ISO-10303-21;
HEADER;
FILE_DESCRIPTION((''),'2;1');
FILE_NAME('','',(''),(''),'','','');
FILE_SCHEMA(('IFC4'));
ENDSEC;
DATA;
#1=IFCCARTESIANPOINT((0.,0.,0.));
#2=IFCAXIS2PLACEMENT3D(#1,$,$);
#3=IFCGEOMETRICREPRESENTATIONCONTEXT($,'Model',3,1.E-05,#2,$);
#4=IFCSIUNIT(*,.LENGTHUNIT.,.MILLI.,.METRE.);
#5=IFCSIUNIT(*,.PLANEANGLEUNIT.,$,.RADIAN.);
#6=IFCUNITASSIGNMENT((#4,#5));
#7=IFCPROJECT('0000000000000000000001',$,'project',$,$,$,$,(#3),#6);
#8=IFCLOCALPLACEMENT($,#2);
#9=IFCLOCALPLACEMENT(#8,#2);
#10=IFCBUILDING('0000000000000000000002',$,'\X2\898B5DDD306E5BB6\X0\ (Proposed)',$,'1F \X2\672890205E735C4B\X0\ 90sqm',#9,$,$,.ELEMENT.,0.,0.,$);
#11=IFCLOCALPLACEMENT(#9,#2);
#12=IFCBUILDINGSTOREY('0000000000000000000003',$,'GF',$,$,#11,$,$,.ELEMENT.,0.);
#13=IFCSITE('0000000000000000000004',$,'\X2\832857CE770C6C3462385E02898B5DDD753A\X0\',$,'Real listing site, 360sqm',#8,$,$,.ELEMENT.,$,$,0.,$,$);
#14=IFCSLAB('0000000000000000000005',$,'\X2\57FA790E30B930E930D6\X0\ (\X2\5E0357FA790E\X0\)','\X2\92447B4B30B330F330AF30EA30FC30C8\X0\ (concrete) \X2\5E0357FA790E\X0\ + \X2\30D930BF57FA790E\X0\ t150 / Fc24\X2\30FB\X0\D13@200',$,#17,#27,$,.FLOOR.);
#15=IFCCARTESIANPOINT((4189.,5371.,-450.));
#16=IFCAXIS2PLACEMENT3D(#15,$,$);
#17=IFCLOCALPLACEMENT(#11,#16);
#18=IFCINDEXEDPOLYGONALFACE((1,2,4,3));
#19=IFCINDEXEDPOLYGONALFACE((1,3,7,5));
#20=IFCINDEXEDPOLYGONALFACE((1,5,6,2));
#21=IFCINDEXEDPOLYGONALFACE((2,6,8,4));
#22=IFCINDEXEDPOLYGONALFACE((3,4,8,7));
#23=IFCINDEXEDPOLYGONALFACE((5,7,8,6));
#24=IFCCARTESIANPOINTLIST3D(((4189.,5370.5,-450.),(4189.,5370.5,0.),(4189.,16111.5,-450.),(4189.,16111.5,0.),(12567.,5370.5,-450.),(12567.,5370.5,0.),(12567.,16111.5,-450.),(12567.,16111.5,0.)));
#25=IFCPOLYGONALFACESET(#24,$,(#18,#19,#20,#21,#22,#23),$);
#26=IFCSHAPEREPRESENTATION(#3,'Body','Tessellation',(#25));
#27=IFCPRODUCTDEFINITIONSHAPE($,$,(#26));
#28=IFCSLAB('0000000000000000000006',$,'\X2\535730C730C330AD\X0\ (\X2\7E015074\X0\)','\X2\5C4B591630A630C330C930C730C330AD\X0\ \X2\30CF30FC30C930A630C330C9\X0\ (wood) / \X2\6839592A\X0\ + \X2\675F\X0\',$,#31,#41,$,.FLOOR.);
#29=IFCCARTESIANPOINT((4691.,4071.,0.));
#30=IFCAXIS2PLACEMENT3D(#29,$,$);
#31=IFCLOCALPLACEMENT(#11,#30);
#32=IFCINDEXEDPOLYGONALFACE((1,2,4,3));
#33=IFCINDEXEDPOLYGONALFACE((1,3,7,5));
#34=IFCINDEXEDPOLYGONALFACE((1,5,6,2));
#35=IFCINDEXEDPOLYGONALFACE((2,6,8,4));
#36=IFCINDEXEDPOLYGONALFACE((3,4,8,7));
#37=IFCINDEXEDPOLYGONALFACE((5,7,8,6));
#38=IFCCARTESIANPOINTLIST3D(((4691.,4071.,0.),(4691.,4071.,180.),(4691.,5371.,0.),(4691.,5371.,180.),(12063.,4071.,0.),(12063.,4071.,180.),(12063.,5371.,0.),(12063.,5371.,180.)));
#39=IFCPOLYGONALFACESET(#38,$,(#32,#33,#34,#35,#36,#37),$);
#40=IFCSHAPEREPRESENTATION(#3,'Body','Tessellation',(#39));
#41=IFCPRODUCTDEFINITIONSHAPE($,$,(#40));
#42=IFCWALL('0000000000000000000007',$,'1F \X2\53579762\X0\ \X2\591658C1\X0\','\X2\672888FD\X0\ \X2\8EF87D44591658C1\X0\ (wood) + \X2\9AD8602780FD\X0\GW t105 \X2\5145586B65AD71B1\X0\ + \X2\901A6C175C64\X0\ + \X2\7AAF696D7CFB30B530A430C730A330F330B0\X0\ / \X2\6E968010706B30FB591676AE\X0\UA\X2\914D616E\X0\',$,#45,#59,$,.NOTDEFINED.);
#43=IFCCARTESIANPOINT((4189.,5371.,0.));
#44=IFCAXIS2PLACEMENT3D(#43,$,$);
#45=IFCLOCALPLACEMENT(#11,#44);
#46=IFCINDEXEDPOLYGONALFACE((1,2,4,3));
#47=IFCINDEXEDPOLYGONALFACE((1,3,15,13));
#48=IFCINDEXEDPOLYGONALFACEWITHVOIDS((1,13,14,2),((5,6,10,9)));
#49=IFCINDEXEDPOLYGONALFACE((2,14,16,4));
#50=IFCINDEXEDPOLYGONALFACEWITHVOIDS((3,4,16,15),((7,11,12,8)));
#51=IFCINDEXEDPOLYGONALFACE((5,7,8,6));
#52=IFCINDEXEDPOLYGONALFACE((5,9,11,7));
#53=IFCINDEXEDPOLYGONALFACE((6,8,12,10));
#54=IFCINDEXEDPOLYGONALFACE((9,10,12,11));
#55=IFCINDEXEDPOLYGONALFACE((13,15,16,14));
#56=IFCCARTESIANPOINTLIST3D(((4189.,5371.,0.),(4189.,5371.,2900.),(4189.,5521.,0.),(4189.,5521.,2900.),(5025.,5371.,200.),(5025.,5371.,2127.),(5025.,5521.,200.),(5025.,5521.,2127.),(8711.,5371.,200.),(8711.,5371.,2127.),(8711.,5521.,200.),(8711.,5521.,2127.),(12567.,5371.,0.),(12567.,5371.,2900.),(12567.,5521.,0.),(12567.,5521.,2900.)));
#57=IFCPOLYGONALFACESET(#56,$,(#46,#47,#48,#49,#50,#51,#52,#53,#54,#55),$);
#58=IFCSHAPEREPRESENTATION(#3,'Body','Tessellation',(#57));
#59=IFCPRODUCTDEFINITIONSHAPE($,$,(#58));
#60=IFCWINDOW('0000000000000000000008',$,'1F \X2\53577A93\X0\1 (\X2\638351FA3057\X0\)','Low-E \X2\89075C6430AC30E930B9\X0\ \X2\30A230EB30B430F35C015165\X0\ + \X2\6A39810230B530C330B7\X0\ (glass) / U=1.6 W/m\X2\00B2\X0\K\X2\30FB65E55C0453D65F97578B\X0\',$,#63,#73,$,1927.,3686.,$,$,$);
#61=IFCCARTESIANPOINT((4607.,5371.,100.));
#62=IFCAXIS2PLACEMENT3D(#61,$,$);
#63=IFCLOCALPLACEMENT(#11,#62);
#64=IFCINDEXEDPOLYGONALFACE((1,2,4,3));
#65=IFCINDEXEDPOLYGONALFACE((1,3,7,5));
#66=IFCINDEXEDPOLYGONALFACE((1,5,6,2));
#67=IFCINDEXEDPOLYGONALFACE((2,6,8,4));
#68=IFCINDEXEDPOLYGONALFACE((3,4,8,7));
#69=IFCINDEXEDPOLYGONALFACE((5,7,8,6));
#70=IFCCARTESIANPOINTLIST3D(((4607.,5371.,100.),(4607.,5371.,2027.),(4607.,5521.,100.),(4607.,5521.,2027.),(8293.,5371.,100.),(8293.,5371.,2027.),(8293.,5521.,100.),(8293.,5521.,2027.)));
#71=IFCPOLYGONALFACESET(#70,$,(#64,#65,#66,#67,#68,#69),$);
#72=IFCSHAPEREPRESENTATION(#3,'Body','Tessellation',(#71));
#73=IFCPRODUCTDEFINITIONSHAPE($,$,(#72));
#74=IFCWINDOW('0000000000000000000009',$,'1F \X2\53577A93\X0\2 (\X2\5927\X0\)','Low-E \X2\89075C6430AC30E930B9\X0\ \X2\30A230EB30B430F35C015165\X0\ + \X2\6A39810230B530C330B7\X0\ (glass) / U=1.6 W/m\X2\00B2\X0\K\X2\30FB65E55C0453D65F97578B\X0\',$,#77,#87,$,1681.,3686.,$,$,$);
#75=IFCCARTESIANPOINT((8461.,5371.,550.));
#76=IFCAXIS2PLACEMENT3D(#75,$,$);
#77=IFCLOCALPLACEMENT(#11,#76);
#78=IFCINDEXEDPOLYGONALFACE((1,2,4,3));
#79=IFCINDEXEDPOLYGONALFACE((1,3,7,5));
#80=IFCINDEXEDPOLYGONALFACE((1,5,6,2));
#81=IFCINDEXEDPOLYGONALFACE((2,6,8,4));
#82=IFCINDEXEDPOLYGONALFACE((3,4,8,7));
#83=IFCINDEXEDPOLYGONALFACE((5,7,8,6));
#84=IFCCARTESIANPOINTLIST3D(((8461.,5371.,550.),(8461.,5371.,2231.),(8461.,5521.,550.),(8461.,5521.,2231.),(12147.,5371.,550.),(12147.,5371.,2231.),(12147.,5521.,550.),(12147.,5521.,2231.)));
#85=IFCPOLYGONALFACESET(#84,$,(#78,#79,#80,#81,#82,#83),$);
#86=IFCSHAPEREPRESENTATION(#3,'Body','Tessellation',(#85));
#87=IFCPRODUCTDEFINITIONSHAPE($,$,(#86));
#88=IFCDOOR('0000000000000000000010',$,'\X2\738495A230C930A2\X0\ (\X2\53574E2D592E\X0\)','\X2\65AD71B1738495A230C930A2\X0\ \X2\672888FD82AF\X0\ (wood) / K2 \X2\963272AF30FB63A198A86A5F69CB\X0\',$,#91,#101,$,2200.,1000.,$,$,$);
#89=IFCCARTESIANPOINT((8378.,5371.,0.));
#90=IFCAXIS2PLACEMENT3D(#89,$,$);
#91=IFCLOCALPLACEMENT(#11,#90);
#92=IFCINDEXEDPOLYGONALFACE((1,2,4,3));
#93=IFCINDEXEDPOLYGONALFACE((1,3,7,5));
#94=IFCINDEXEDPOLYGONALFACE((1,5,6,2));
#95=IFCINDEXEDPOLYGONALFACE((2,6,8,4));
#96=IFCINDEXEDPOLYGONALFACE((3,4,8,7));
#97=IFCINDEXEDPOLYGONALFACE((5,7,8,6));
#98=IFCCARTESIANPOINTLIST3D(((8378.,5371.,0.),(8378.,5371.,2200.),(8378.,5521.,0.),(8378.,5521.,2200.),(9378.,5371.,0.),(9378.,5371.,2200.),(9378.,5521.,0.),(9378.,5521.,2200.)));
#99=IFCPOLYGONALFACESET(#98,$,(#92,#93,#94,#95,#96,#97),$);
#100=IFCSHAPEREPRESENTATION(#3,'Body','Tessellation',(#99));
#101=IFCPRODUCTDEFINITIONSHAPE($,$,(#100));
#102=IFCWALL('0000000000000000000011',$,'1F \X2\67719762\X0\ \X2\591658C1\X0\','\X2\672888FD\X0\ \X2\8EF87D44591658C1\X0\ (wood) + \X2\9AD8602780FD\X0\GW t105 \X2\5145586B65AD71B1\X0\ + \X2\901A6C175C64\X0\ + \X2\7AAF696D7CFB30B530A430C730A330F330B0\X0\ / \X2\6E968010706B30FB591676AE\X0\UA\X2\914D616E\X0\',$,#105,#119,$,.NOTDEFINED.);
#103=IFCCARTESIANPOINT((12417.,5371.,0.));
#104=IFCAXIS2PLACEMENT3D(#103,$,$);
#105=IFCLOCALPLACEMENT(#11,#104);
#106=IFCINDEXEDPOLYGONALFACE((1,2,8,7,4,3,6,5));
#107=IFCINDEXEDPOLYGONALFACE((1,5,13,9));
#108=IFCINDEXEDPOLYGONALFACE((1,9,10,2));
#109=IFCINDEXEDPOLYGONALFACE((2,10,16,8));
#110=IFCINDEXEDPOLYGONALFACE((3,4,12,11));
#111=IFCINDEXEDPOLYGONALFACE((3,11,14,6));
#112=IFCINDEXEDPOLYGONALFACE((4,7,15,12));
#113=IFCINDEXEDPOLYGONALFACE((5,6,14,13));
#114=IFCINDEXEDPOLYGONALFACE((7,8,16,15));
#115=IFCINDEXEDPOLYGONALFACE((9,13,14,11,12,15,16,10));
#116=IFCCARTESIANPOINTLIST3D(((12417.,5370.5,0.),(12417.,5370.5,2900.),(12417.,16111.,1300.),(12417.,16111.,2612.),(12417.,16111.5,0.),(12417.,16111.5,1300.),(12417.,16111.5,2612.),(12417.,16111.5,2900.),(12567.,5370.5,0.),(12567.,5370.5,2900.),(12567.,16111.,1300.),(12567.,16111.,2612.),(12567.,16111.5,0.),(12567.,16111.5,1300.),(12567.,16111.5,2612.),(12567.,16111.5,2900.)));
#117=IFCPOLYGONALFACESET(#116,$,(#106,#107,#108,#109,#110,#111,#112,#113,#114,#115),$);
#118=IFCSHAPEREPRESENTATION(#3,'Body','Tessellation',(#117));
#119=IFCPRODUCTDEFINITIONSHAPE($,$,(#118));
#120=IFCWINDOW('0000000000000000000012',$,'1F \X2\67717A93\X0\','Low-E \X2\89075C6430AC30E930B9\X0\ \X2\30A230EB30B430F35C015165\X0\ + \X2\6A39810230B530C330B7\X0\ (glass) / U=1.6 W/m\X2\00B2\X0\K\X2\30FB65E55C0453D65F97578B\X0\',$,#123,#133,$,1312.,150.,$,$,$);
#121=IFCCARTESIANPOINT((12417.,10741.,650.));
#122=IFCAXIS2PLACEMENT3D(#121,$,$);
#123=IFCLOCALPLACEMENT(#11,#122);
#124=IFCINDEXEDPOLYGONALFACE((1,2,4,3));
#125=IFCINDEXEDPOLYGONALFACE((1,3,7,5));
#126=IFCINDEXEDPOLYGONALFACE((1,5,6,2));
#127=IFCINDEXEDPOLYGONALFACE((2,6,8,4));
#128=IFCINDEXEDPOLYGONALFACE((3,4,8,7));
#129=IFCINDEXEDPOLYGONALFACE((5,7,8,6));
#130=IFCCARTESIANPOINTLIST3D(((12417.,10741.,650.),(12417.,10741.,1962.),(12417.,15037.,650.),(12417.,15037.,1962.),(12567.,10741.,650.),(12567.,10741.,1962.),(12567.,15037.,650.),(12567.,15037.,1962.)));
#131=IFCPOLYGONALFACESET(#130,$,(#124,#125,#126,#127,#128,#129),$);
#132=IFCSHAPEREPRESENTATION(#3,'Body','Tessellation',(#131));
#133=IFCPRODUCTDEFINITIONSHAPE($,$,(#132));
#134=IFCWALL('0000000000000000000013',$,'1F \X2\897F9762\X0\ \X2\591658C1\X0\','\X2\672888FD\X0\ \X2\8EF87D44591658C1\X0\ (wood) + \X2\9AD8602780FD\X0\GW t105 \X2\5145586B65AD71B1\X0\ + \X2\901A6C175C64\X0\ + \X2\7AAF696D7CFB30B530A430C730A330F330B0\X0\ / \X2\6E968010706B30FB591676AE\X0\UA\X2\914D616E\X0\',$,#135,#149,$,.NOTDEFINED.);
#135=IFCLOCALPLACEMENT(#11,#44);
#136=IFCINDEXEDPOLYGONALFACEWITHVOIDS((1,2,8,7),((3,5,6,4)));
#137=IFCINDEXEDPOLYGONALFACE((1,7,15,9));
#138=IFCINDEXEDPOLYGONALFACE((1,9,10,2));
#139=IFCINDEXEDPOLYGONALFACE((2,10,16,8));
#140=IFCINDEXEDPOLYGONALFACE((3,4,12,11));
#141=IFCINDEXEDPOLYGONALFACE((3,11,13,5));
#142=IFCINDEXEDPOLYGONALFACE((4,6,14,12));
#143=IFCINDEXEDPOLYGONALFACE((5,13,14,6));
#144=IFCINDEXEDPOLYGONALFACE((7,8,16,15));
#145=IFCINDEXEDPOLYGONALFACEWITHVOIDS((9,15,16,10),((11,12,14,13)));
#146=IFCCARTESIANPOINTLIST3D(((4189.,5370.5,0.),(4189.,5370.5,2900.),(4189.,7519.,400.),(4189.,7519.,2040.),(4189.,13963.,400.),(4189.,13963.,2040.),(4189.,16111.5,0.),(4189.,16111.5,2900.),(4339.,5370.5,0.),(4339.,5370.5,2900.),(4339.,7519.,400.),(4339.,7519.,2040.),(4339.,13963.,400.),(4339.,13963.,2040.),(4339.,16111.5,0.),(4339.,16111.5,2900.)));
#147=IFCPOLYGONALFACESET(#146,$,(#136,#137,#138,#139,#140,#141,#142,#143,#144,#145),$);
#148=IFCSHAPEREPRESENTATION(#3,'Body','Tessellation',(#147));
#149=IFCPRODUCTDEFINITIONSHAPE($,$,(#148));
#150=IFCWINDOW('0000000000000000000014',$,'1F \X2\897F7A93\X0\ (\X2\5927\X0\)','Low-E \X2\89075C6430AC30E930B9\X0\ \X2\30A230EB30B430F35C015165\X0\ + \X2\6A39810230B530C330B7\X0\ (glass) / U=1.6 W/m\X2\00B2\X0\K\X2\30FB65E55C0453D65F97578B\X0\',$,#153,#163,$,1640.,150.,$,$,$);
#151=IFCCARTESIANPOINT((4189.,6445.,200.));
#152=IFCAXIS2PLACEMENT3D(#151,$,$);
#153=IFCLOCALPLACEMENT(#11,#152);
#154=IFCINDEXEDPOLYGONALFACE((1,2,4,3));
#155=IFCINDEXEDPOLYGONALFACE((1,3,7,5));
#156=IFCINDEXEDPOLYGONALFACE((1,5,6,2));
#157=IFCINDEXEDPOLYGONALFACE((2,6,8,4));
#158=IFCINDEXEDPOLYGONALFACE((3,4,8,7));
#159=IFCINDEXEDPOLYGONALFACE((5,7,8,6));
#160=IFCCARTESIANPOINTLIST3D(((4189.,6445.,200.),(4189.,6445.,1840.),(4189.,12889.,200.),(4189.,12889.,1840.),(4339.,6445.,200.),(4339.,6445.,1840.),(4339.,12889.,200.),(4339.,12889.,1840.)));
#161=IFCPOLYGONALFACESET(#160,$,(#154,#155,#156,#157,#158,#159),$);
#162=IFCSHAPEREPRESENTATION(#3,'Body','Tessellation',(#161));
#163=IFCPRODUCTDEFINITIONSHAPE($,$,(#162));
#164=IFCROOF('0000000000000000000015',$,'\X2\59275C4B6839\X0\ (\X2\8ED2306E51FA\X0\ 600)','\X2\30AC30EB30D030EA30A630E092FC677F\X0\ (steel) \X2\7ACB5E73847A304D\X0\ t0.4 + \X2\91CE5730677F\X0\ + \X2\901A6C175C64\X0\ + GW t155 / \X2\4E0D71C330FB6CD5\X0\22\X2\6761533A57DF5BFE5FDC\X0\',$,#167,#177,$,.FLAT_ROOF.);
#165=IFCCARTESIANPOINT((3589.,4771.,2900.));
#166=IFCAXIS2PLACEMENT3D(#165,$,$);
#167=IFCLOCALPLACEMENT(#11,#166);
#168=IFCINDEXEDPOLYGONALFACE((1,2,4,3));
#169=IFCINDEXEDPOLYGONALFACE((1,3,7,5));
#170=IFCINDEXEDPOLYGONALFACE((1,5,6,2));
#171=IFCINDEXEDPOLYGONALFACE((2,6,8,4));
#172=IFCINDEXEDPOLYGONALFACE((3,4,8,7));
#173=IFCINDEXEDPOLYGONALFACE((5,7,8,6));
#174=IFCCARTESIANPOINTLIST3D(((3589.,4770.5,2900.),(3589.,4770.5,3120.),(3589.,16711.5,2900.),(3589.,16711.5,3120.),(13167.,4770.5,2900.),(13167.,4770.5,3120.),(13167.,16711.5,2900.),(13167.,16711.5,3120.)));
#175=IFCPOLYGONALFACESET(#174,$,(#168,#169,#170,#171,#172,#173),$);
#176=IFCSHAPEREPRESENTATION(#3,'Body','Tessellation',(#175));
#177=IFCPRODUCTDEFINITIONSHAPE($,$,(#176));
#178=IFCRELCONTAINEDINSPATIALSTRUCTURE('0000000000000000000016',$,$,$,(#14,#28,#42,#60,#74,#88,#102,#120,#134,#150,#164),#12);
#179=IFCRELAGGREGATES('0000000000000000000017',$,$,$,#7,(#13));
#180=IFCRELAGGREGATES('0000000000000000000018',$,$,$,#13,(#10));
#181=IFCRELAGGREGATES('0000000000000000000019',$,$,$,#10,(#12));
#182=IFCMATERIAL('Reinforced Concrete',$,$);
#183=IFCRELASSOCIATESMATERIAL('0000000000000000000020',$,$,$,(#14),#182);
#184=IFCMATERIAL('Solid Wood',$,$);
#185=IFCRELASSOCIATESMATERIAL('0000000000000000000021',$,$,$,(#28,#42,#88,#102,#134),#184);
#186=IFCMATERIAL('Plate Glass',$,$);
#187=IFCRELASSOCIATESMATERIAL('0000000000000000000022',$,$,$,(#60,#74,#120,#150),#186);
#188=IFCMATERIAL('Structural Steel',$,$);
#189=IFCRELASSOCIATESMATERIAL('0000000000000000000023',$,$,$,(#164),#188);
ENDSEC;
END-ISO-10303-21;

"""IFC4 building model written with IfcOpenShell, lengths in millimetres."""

from ifc_helpers import new_model, si_unit, frame, frame_2d, origin, place, context, project, spatial, rectangle, extrude, material, element, fill, save


model = new_model("IFC4")

# Units and contexts
model_context = context("Model", 3, precision=1e-05, world=origin())
ifc_project = project(units=[si_unit("LENGTHUNIT", "METRE", prefix="MILLI"), si_unit("PLANEANGLEUNIT", "RADIAN")], contexts=[model_context])

# Site, building, storey
site_placement = place(None, origin())
site = spatial("IfcSite", under=ifc_project, at=site_placement, Name="茨城県水戸市見川町", ObjectType="Real listing site, 360sqm", CompositionType="ELEMENT", RefElevation=0.0)
building_placement = place(site_placement, origin())
building = spatial("IfcBuilding", under=site, at=building_placement, Name="見川の家 (Proposed)", ObjectType="1F 木造平屋 90sqm", CompositionType="ELEMENT", ElevationOfRefHeight=0.0, ElevationOfTerrain=0.0)
storey_placement = place(building_placement, origin())
storey = spatial("IfcBuildingStorey", under=building, at=storey_placement, Name="GF", CompositionType="ELEMENT", Elevation=0.0)

# Slabs
ifc_material_1 = material(Name="Reinforced Concrete")
slab_1_placement = place(storey_placement, frame((4189.0, 5371.0, -450.0)))
element("IfcSlab", 1, at=slab_1_placement, inside=storey, material=ifc_material_1, Name="基礎スラブ (布基礎)", Description="鉄筋コンクリート (concrete) 布基礎 + ベタ基礎 t150 / Fc24・D13@200", PredefinedType="FLOOR", context=model_context, shape_type="SweptSolid", body=[
    extrude(rectangle(XDim=8378.0, YDim=10741.0, at=frame_2d((4189.0, 5370.0))), frame((4189.0, 5371.0, -450.0)), (0.0, 0.0, 1.0), 450.0),
])
ifc_material_2 = material(Name="Solid Wood")
slab_2_placement = place(storey_placement, frame((4691.0, 4071.0, 0.0)))
element("IfcSlab", 2, at=slab_2_placement, inside=storey, material=ifc_material_2, Name="南デッキ (縁側)", Description="屋外ウッドデッキ ハードウッド (wood) / 根太 + 束", PredefinedType="FLOOR", context=model_context, shape_type="SweptSolid", body=[
    extrude(rectangle(XDim=7372.0, YDim=1300.0, at=frame_2d((3686.0, 650.0))), frame((4691.0, 4071.0, 0.0)), (0.0, 0.0, 1.0), 180.0),
])

# Wall, openings, windows, door
wall_1_placement = place(storey_placement, frame((4189.0, 5371.0, 0.0)))
wall_1 = element("IfcWall", 3, at=wall_1_placement, inside=storey, material=ifc_material_2, Name="1F 南面 外壁", Description="木製 軸組外壁 (wood) + 高性能GW t105 充填断熱 + 通気層 + 窯業系サイディング / 準耐火・外皮UA配慮", PredefinedType="NOTDEFINED", context=model_context, shape_type="SweptSolid", body=[
    extrude(rectangle(XDim=8378.0, YDim=150.0, at=frame_2d((4189.0, 75.0))), frame((4189.0, 5371.0, 0.0)), (0.0, 0.0, 1.0), 2900.0),
])
opening_1_placement = place(storey_placement, frame((4607.0, 5371.0, 100.0)))
opening_1 = element("IfcOpeningElement", 4, at=opening_1_placement, cuts=wall_1, PredefinedType="NOTDEFINED", context=model_context, shape_type="SweptSolid", body=[
    extrude(rectangle(XDim=3686.0, YDim=150.0, at=frame_2d((1843.0, 75.0))), frame((4607.0, 5371.0, 100.0)), (0.0, 0.0, 1.0), 1927.0),
])
opening_2_placement = place(storey_placement, frame((8461.0, 5371.0, 550.0)))
opening_2 = element("IfcOpeningElement", 5, at=opening_2_placement, cuts=wall_1, PredefinedType="NOTDEFINED", context=model_context, shape_type="SweptSolid", body=[
    extrude(rectangle(XDim=3686.0, YDim=150.0, at=frame_2d((1843.0, 75.0))), frame((8461.0, 5371.0, 550.0)), (0.0, 0.0, 1.0), 1681.0),
])
opening_3_placement = place(storey_placement, frame((8378.0, 5371.0, 0.0)))
opening_3 = element("IfcOpeningElement", 6, at=opening_3_placement, cuts=wall_1, PredefinedType="NOTDEFINED", context=model_context, shape_type="SweptSolid", body=[
    extrude(rectangle(XDim=1000.0, YDim=150.0, at=frame_2d((500.0, 75.0))), frame((8378.0, 5371.0, 0.0)), (0.0, 0.0, 1.0), 2200.0),
])
ifc_material_3 = material(Name="Plate Glass")
window_1_placement = place(storey_placement, frame((4607.0, 5371.0, 100.0)))
window_1 = element("IfcWindow", 7, at=window_1_placement, inside=storey, material=ifc_material_3, Name="1F 南窓1 (掃出し)", Description="Low-E 複層ガラス アルゴン封入 + 樹脂サッシ (glass) / U=1.6 W/m²K・日射取得型", OverallHeight=1927.0, OverallWidth=3686.0, context=model_context, shape_type="SweptSolid", body=[
    extrude(rectangle(XDim=3686.0, YDim=150.0, at=frame_2d((1843.0, 75.0))), frame((4607.0, 5371.0, 100.0)), (0.0, 0.0, 1.0), 1927.0),
])
fill(opening_1, window_1)
window_2_placement = place(storey_placement, frame((8461.0, 5371.0, 550.0)))
window_2 = element("IfcWindow", 8, at=window_2_placement, inside=storey, material=ifc_material_3, Name="1F 南窓2 (大)", Description="Low-E 複層ガラス アルゴン封入 + 樹脂サッシ (glass) / U=1.6 W/m²K・日射取得型", OverallHeight=1681.0, OverallWidth=3686.0, context=model_context, shape_type="SweptSolid", body=[
    extrude(rectangle(XDim=3686.0, YDim=150.0, at=frame_2d((1843.0, 75.0))), frame((8461.0, 5371.0, 550.0)), (0.0, 0.0, 1.0), 1681.0),
])
fill(opening_2, window_2)
door_placement = place(storey_placement, frame((8378.0, 5371.0, 0.0)))
door = element("IfcDoor", 9, at=door_placement, inside=storey, material=ifc_material_2, Name="玄関ドア (南中央)", Description="断熱玄関ドア 木製芯 (wood) / K2 防犯・採風機構", OverallHeight=2200.0, OverallWidth=1000.0, context=model_context, shape_type="SweptSolid", body=[
    extrude(rectangle(XDim=1000.0, YDim=150.0, at=frame_2d((500.0, 75.0))), frame((8378.0, 5371.0, 0.0)), (0.0, 0.0, 1.0), 2200.0),
])
fill(opening_3, door)

# Walls, openings, windows
wall_2_placement = place(storey_placement, frame((12417.0, 5371.0, 0.0)))
wall_2 = element("IfcWall", 10, at=wall_2_placement, inside=storey, material=ifc_material_2, Name="1F 東面 外壁", Description="木製 軸組外壁 (wood) + 高性能GW t105 充填断熱 + 通気層 + 窯業系サイディング / 準耐火・外皮UA配慮", PredefinedType="NOTDEFINED", context=model_context, shape_type="SweptSolid", body=[
    extrude(rectangle(XDim=150.0, YDim=10741.0, at=frame_2d((75.0, 5370.0))), frame((12417.0, 5371.0, 0.0)), (0.0, 0.0, 1.0), 2900.0),
])
opening_4_placement = place(storey_placement, frame((12417.0, 10741.0, 650.0)))
opening_4 = element("IfcOpeningElement", 11, at=opening_4_placement, cuts=wall_2, PredefinedType="NOTDEFINED", context=model_context, shape_type="SweptSolid", body=[
    extrude(rectangle(XDim=150.0, YDim=4296.0, at=frame_2d((75.0, 2148.0))), frame((12417.0, 10741.0, 650.0)), (0.0, 0.0, 1.0), 1312.0),
])
window_3_placement = place(storey_placement, frame((12417.0, 10741.0, 650.0)))
window_3 = element("IfcWindow", 12, at=window_3_placement, inside=storey, material=ifc_material_3, Name="1F 東窓", Description="Low-E 複層ガラス アルゴン封入 + 樹脂サッシ (glass) / U=1.6 W/m²K・日射取得型", OverallHeight=1312.0, OverallWidth=150.0, context=model_context, shape_type="SweptSolid", body=[
    extrude(rectangle(XDim=150.0, YDim=4296.0, at=frame_2d((75.0, 2148.0))), frame((12417.0, 10741.0, 650.0)), (0.0, 0.0, 1.0), 1312.0),
])
fill(opening_4, window_3)
wall_3_placement = place(storey_placement, frame((4189.0, 5371.0, 0.0)))
wall_3 = element("IfcWall", 13, at=wall_3_placement, inside=storey, material=ifc_material_2, Name="1F 西面 外壁", Description="木製 軸組外壁 (wood) + 高性能GW t105 充填断熱 + 通気層 + 窯業系サイディング / 準耐火・外皮UA配慮", PredefinedType="NOTDEFINED", context=model_context, shape_type="SweptSolid", body=[
    extrude(rectangle(XDim=150.0, YDim=10741.0, at=frame_2d((75.0, 5370.0))), frame((4189.0, 5371.0, 0.0)), (0.0, 0.0, 1.0), 2900.0),
])
opening_5_placement = place(storey_placement, frame((4189.0, 6445.0, 200.0)))
opening_5 = element("IfcOpeningElement", 14, at=opening_5_placement, cuts=wall_3, PredefinedType="NOTDEFINED", context=model_context, shape_type="SweptSolid", body=[
    extrude(rectangle(XDim=150.0, YDim=6444.0, at=frame_2d((75.0, 3222.0))), frame((4189.0, 6445.0, 200.0)), (0.0, 0.0, 1.0), 1640.0),
])
window_4_placement = place(storey_placement, frame((4189.0, 6445.0, 200.0)))
window_4 = element("IfcWindow", 15, at=window_4_placement, inside=storey, material=ifc_material_3, Name="1F 西窓 (大)", Description="Low-E 複層ガラス アルゴン封入 + 樹脂サッシ (glass) / U=1.6 W/m²K・日射取得型", OverallHeight=1640.0, OverallWidth=150.0, context=model_context, shape_type="SweptSolid", body=[
    extrude(rectangle(XDim=150.0, YDim=6444.0, at=frame_2d((75.0, 3222.0))), frame((4189.0, 6445.0, 200.0)), (0.0, 0.0, 1.0), 1640.0),
])
fill(opening_5, window_4)

# Roof
ifc_material_4 = material(Name="Structural Steel")
roof_placement = place(storey_placement, frame((3589.0, 4771.0, 2900.0)))
element("IfcRoof", 16, at=roof_placement, inside=storey, material=ifc_material_4, Name="大屋根 (軒の出 600)", Description="ガルバリウム鋼板 (steel) 立平葺き t0.4 + 野地板 + 通気層 + GW t155 / 不燃・法22条区域対応", PredefinedType="FLAT_ROOF", context=model_context, shape_type="SweptSolid", body=[
    extrude(rectangle(XDim=9578.0, YDim=11941.0, at=frame_2d((4789.0, 5970.0))), frame((3589.0, 4771.0, 2900.0)), (0.0, 0.0, 1.0), 220.0),
])

save(model, "model.ifc")
